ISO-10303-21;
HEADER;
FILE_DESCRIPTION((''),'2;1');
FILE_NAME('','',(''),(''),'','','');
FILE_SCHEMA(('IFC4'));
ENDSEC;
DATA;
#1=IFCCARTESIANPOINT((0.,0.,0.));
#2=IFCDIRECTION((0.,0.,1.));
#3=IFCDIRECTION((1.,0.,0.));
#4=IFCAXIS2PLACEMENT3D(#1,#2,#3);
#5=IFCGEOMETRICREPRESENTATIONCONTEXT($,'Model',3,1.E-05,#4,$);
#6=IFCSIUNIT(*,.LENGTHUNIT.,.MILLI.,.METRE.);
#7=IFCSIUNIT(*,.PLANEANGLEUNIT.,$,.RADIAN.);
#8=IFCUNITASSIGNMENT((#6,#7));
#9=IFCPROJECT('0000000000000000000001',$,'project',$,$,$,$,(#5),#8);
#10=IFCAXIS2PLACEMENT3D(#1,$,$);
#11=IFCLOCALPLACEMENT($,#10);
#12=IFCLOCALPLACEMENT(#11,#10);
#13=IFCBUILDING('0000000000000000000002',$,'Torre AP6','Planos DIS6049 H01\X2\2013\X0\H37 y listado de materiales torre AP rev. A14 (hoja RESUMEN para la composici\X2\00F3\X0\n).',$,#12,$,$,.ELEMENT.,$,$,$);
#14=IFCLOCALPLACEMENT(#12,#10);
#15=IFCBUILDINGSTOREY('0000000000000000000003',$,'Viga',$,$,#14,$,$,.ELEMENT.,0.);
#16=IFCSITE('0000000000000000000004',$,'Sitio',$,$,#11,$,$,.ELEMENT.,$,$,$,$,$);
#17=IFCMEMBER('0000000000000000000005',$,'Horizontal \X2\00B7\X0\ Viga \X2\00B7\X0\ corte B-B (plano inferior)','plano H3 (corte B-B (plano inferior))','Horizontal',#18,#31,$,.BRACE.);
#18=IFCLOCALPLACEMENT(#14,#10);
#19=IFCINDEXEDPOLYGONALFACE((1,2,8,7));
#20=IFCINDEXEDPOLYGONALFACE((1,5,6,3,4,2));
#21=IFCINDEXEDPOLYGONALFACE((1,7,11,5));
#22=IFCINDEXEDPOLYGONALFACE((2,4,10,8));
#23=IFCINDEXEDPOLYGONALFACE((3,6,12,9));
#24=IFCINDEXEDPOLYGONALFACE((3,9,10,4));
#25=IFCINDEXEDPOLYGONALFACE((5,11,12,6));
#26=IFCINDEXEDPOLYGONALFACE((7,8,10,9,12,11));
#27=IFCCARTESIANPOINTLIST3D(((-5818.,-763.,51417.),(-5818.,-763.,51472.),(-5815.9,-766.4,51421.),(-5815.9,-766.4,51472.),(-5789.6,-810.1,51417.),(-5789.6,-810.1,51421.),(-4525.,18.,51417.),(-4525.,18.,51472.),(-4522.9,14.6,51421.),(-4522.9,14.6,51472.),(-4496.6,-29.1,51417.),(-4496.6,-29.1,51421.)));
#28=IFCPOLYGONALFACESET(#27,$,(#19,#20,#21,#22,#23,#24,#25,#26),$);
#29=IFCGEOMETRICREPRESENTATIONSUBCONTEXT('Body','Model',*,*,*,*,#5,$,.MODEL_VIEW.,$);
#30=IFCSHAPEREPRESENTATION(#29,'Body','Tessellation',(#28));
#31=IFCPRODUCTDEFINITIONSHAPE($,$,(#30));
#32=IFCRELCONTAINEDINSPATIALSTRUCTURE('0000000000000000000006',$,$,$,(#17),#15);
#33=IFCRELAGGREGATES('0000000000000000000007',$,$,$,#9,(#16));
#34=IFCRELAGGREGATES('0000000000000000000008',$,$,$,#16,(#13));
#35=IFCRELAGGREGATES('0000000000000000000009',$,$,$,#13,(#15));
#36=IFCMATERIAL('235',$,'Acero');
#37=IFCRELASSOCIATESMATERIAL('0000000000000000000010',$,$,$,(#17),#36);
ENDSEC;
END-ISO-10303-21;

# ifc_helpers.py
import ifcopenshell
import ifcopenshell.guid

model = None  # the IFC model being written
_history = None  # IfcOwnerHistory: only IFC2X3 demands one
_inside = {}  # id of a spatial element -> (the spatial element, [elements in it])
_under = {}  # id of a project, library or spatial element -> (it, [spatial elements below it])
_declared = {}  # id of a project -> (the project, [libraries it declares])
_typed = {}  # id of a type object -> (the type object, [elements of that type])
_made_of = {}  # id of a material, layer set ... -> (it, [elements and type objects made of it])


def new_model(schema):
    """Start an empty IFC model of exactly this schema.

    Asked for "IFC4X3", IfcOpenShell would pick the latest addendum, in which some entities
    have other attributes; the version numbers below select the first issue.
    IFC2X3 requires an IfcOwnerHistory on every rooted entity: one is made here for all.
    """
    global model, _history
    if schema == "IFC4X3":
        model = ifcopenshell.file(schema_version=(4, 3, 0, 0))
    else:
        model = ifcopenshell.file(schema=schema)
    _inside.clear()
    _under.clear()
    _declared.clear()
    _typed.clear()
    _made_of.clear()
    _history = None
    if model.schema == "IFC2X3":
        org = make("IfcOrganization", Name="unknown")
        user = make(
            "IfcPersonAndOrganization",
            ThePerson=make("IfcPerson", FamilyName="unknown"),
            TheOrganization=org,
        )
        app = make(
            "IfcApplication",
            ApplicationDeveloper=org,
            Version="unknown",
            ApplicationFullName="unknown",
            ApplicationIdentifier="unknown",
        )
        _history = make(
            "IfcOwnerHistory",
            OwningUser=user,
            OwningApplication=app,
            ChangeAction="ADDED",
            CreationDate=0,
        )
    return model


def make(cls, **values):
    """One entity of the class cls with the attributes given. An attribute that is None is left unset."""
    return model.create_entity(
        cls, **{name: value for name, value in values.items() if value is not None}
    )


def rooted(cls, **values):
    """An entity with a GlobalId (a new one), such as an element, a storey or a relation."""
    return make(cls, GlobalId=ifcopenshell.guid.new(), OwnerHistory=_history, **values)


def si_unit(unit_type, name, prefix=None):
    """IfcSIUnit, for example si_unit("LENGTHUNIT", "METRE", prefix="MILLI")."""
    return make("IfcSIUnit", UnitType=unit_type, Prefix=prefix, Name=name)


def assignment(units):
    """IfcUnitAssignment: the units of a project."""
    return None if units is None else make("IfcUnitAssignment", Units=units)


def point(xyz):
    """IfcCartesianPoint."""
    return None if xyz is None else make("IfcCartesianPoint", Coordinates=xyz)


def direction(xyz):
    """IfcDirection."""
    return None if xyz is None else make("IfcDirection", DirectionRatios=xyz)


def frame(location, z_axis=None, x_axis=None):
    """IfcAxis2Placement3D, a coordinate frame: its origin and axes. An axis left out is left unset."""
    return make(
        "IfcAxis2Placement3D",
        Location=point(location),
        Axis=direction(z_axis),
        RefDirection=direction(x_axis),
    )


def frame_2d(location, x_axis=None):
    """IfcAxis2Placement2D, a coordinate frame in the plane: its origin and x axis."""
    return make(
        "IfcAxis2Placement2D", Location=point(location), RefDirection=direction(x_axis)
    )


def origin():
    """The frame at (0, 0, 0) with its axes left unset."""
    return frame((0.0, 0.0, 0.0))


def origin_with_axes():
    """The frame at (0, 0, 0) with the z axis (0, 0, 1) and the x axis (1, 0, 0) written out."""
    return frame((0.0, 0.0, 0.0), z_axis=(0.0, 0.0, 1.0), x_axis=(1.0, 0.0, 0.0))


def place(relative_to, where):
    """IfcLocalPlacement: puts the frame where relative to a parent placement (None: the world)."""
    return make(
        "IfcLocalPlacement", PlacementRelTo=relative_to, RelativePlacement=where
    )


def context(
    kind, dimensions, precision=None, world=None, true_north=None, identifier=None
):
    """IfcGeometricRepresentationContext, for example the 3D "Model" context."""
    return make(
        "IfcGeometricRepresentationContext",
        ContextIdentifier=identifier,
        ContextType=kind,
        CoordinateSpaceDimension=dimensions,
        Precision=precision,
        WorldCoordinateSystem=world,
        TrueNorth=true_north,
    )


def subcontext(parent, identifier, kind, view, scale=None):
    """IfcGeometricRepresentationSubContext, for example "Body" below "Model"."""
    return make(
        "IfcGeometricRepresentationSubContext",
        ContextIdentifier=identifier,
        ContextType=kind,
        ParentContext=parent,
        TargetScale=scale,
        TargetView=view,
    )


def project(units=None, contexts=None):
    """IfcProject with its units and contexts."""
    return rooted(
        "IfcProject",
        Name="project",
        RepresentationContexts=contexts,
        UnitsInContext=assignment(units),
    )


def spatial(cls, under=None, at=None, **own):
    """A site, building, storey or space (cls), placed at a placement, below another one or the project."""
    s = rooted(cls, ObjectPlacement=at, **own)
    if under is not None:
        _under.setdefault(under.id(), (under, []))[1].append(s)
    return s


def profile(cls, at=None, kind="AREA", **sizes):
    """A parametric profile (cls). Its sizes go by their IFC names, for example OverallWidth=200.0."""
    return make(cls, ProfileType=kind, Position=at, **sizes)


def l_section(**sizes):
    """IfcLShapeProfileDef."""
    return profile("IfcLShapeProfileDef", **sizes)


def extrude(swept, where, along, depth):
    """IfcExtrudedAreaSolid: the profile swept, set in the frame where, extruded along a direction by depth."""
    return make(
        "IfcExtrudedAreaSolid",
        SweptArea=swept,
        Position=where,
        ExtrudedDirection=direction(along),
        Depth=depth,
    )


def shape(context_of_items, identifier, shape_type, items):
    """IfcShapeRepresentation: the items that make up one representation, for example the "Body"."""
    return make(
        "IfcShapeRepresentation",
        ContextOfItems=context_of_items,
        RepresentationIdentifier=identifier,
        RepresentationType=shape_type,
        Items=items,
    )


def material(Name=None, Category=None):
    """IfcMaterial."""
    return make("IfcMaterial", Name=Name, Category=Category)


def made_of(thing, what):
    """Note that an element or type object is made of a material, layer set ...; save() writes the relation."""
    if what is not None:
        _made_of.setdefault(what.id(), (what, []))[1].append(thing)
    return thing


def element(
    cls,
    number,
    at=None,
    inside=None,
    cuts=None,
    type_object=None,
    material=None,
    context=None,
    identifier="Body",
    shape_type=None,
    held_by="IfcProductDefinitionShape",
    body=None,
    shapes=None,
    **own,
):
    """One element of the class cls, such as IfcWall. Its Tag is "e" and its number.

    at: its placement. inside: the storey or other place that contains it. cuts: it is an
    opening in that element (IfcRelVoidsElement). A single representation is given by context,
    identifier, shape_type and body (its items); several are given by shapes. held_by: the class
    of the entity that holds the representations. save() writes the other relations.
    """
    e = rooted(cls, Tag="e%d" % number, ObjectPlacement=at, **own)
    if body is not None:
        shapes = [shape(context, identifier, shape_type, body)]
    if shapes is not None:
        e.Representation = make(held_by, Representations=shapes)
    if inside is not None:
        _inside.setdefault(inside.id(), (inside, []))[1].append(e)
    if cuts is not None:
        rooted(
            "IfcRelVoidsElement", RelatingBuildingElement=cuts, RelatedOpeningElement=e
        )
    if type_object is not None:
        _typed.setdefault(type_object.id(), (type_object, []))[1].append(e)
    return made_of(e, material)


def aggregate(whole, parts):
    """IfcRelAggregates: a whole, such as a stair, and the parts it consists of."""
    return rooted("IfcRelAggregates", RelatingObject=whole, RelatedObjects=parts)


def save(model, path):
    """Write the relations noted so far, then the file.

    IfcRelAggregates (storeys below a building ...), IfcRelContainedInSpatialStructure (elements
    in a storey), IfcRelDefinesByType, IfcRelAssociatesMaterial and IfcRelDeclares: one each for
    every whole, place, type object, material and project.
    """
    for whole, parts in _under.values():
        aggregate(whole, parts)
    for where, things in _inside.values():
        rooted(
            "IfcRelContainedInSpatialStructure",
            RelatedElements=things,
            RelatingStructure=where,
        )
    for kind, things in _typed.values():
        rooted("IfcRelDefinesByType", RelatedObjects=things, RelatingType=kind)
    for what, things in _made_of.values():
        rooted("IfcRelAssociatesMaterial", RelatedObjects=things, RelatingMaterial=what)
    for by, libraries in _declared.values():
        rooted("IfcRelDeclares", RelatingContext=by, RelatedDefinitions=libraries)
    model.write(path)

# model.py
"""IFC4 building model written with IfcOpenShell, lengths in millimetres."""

from ifc_helpers import new_model, si_unit, frame, frame_2d, origin, origin_with_axes, place, context, subcontext, project, spatial, l_section, extrude, material, element, save


model = new_model("IFC4")

# Units and contexts
model_context = context("Model", 3, precision=1e-05, world=origin_with_axes())
body_context = subcontext(model_context, "Body", "Model", "MODEL_VIEW")
ifc_project = project(units=[si_unit("LENGTHUNIT", "METRE", prefix="MILLI"), si_unit("PLANEANGLEUNIT", "RADIAN")], contexts=[model_context])

# Site, building, storey
site_placement = place(None, origin())
site = spatial("IfcSite", under=ifc_project, at=site_placement, Name="Sitio", CompositionType="ELEMENT")
building_placement = place(site_placement, origin())
building = spatial("IfcBuilding", under=site, at=building_placement, Name="Torre AP6", Description="Planos DIS6049 H01–H37 y listado de materiales torre AP rev. A14 (hoja RESUMEN para la composición).", CompositionType="ELEMENT")
storey_placement = place(building_placement, origin())
storey = spatial("IfcBuildingStorey", under=building, at=storey_placement, Name="Viga", CompositionType="ELEMENT", Elevation=0.0)

# Member
ifc_material = material(Name="235", Category="Acero")
member_1_placement = place(storey_placement, frame((-4525.0, 18.0, 51417.0), z_axis=(-0.85597, -0.517025, 0.0), x_axis=(0.517025, -0.85597, 0.0)))
element("IfcMember", 1, at=member_1_placement, inside=storey, material=ifc_material, Name="Horizontal · Viga · corte B-B (plano inferior)", Description="plano H3 (corte B-B (plano inferior))", ObjectType="Horizontal", PredefinedType="BRACE", context=body_context, shape_type="SweptSolid", body=[
    extrude(l_section(Depth=55.0, Width=55.0, Thickness=4.0, at=frame_2d((27.5, 27.5))), None, (0.0, 0.0, 1.0), 1510.6),
])

save(model, "model.ifc")
